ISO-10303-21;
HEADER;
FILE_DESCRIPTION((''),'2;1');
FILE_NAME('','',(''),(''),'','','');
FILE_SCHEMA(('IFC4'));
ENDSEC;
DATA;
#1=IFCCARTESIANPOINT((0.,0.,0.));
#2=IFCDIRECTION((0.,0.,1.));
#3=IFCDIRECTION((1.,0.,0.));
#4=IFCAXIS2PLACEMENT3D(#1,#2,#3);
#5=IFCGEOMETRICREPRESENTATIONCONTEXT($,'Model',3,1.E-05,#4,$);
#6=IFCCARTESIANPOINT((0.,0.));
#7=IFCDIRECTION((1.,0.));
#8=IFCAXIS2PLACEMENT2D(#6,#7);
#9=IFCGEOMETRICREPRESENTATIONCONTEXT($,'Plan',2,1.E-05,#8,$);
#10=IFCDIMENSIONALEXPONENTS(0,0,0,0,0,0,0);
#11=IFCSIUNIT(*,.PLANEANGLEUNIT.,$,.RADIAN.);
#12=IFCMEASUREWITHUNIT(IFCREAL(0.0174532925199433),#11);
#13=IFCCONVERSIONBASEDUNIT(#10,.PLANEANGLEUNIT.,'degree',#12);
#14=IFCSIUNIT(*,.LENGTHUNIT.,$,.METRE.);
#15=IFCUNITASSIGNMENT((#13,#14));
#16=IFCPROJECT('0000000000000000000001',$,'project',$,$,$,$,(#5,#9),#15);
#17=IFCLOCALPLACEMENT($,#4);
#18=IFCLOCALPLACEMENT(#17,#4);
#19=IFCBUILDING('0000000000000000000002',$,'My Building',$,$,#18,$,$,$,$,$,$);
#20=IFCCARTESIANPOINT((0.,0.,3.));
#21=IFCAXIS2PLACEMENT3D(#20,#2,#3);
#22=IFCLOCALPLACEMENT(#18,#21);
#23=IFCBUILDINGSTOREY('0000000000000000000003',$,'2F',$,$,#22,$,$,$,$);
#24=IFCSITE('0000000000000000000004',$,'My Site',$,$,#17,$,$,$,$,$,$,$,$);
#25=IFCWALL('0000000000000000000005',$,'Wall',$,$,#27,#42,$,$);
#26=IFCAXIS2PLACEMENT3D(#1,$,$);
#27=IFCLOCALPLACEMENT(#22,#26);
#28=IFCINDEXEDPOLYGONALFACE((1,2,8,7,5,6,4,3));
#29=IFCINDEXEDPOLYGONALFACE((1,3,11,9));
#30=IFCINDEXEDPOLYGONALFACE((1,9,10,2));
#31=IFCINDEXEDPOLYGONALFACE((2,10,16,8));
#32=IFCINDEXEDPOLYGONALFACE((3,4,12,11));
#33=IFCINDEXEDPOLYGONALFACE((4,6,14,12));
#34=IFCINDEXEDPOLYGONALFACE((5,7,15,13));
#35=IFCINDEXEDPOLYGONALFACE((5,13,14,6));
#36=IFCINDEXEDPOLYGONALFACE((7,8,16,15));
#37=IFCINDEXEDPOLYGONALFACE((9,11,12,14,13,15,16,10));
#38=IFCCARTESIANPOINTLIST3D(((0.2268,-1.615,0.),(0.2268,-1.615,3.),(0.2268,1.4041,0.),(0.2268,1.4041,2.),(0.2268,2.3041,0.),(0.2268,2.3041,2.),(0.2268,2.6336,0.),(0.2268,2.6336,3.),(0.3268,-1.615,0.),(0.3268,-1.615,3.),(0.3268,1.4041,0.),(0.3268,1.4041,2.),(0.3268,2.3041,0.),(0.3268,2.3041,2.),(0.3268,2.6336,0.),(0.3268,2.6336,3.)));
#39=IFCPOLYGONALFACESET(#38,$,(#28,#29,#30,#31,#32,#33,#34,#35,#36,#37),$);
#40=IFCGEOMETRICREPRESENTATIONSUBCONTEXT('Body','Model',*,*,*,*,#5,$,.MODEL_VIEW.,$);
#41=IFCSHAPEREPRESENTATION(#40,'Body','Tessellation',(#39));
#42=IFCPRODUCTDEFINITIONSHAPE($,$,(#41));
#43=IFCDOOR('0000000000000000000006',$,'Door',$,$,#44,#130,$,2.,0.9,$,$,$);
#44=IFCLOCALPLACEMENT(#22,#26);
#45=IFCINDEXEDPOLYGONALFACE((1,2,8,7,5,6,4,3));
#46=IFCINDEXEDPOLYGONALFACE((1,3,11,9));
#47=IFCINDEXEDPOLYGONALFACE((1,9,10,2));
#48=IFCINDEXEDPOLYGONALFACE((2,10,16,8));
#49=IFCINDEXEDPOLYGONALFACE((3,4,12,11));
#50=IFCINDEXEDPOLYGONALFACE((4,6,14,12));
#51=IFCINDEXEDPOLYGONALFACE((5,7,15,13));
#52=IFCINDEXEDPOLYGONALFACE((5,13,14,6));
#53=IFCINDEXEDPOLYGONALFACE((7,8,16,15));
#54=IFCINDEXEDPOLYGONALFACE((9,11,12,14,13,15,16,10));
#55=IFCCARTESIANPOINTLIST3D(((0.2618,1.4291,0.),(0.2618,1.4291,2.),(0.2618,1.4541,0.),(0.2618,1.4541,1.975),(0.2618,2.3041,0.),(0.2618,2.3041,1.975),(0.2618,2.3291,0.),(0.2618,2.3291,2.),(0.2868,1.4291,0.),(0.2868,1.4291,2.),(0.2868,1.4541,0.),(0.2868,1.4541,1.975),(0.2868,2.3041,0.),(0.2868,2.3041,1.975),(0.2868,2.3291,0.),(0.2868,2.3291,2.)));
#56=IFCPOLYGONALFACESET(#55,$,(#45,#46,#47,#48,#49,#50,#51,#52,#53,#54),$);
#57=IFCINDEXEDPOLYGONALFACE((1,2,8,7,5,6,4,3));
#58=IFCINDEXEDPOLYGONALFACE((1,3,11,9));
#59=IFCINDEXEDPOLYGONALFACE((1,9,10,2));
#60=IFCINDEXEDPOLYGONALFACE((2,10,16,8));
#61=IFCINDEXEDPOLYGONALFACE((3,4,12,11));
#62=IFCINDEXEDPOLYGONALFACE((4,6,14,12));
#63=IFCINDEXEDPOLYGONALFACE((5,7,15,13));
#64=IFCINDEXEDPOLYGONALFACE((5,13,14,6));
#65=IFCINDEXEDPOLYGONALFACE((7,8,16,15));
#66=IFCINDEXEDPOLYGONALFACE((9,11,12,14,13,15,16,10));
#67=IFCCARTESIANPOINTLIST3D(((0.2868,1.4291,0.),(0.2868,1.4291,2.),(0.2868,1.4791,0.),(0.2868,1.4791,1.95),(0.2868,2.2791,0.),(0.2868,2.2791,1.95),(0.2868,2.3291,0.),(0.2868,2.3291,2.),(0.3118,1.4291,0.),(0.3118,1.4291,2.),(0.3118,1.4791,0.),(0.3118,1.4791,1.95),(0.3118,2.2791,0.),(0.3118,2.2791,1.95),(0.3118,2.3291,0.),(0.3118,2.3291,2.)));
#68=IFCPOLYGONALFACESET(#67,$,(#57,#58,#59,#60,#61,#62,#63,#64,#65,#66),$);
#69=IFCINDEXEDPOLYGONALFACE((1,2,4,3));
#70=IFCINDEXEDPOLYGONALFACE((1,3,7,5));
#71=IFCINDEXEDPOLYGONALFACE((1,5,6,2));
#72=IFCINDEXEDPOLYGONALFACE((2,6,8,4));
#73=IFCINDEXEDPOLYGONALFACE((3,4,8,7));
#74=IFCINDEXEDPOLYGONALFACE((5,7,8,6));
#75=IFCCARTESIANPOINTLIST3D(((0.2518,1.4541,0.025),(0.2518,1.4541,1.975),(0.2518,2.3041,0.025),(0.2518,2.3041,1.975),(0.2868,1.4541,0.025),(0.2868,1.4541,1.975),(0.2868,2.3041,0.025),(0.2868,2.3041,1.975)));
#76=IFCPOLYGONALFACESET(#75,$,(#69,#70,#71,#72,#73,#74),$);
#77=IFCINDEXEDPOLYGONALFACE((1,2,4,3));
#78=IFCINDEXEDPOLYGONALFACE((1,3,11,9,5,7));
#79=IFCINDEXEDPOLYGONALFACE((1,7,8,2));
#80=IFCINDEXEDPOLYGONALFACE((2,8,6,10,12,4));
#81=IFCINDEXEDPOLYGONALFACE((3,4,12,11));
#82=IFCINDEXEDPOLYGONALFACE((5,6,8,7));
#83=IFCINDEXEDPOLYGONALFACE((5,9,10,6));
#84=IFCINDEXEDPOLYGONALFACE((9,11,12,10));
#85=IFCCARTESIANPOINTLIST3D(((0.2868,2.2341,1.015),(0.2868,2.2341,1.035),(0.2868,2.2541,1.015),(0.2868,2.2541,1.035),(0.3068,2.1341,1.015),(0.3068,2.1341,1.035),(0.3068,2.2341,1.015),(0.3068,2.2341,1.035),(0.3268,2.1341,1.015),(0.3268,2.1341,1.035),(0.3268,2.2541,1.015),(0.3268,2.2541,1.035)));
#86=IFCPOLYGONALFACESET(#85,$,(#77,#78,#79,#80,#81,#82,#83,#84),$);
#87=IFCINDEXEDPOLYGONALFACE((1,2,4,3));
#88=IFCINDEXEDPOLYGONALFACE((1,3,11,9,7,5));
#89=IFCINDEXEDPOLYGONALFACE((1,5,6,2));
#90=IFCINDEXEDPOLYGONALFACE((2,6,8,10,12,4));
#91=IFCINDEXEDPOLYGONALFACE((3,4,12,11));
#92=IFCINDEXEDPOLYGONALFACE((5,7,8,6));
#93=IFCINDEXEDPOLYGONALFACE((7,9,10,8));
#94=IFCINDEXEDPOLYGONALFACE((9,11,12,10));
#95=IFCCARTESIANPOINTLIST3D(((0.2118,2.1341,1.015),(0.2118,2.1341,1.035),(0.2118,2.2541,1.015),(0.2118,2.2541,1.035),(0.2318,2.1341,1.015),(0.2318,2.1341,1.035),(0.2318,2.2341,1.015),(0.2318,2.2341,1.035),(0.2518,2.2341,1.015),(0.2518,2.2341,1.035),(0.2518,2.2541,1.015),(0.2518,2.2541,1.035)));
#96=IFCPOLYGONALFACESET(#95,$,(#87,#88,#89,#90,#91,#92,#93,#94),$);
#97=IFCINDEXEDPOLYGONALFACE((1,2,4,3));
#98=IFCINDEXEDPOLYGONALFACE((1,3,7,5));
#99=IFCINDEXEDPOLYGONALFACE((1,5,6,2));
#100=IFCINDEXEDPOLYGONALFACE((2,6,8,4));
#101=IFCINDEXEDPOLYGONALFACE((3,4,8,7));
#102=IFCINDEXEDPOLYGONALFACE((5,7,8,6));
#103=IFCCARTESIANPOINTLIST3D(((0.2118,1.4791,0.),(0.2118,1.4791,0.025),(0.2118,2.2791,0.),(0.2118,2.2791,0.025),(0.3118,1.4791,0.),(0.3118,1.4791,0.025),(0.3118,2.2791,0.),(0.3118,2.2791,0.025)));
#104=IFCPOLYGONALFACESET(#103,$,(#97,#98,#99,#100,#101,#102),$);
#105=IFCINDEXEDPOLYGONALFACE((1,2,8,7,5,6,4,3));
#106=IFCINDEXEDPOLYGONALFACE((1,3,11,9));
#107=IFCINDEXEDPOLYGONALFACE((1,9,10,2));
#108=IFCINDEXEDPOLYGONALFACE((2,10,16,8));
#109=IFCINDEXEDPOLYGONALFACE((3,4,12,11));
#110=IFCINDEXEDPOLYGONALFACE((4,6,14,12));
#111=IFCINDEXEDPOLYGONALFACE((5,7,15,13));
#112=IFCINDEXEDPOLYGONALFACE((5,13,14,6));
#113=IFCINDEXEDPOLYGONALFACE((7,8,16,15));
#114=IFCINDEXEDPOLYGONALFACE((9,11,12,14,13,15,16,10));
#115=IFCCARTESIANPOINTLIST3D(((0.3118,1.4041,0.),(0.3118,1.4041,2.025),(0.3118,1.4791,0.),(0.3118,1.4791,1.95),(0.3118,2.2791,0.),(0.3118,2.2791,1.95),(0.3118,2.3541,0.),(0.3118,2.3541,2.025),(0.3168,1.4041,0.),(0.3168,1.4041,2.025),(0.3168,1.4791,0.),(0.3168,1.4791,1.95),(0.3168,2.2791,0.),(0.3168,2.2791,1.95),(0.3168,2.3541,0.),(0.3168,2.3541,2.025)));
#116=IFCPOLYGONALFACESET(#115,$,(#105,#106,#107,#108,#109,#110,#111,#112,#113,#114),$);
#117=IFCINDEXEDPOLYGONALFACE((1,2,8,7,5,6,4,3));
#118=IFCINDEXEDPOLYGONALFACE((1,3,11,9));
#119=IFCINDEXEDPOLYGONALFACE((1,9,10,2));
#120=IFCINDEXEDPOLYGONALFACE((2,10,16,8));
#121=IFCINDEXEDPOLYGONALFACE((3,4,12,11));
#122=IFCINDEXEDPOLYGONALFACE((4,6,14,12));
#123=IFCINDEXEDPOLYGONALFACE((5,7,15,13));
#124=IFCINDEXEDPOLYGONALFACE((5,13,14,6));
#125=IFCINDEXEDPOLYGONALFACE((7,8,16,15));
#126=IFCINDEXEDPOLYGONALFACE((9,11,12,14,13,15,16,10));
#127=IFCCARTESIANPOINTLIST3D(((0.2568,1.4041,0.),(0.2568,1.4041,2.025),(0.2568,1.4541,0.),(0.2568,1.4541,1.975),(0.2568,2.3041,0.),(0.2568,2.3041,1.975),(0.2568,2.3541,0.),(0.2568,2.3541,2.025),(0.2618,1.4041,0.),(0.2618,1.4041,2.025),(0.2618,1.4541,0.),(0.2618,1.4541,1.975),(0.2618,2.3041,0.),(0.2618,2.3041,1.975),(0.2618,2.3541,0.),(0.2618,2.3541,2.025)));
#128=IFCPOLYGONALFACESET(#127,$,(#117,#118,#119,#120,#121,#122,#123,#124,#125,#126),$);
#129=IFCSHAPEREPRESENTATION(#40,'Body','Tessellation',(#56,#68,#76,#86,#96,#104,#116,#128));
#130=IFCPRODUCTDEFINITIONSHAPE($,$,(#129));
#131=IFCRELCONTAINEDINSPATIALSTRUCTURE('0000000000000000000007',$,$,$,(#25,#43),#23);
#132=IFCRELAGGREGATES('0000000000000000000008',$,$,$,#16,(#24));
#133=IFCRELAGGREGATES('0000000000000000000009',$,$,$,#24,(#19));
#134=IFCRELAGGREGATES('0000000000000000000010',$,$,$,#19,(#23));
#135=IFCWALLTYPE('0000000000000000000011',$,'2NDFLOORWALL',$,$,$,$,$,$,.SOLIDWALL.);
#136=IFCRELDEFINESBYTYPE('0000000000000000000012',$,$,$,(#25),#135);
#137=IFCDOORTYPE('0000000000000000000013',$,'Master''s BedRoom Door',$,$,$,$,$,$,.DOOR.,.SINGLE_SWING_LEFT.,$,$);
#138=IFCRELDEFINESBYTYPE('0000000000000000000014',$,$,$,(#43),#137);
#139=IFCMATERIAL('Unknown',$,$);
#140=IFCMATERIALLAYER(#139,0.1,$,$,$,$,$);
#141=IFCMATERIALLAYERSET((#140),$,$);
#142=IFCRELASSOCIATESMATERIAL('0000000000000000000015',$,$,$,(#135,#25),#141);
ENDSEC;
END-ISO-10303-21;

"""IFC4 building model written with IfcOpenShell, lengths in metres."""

from ifc_helpers import new_model, entity, si_unit, converted_unit, frame, origin_with_axes, origin_2d_with_axis, place, context, subcontext, project, spatial, line, indexed_curve, outline, extrude, shape, source, transform, mapped, material, layer, layer_set, layer_usage, type_object, type_shapes, element, fill, save


model = new_model("IFC4")

# Units and contexts
model_context = context("Model", 3, precision=1e-05, world=origin_with_axes())
plan_context = context("Plan", 2, precision=1e-05, world=origin_2d_with_axis())
body_context_1 = subcontext(model_context, "Body", "Model", "MODEL_VIEW")
body_context_2 = subcontext(plan_context, "Body", "Plan", "PLAN_VIEW")
ifc_project = project(units=[converted_unit("PLANEANGLEUNIT", "degree", entity("IfcReal", 0.0174532925199433), si_unit("PLANEANGLEUNIT", "RADIAN"), dimensions=[0, 0, 0, 0, 0, 0, 0]), si_unit("LENGTHUNIT", "METRE")], contexts=[model_context, plan_context])

# Site, building, storey
site_placement = place(None, origin_with_axes())
site = spatial("IfcSite", under=ifc_project, at=site_placement, Name="My Site")
building_placement = place(site_placement, origin_with_axes())
building = spatial("IfcBuilding", under=site, at=building_placement, Name="My Building")
storey_placement = place(building_placement, frame((0.0, 0.0, 3.0), z_axis=(0.0, 0.0, 1.0), x_axis=(1.0, 0.0, 0.0)))
storey = spatial("IfcBuildingStorey", under=building, at=storey_placement, Name="2F")

# Shared definitions
ifc_material = material(Name="Unknown")

# Shared definitions
ifc_layer_1 = layer(ifc_material, 0.1)
ifc_layer_set_1 = layer_set([ifc_layer_1])
wall_type_1 = type_object("IfcWallType", Name="2NDFLOORWALL", PredefinedType="SOLIDWALL", material=ifc_layer_set_1)

# Wall, opening, door
shared_shape_1 = source(origin_with_axes(), body_context_1, "Body", "SweptSolid", [
    extrude(outline(indexed_curve([(0.0, 0.0), (0.9, 0.0), (0.9, 2.0), (0.0, 2.0)], segments=[line(1, 2, 3, 4, 1)])), frame((0.0, -0.6, 0.0), z_axis=(0.0, -1.0, 0.0), x_axis=(1.0, 0.0, 0.0)), (0.0, 0.0, -1.0), 1.2),
])
door_type_1 = type_object("IfcDoorType", Name="Master's BedRoom Door", OperationType="SINGLE_SWING_LEFT", PredefinedType="DOOR")
shared_shape_2 = source(origin_with_axes(), body_context_1, "Body", "SweptSolid", [
    extrude(outline(indexed_curve([(0.0, 0.0), (0.0, 2.0), (0.9, 2.0), (0.9, 0.0), (0.875, 0.0), (0.875, 1.975), (0.025, 1.975), (0.025, 0.0)], segments=[line(1, 2, 3, 4, 5, 6, 7, 8, 1)])), frame((0.0, 0.025, 0.0), z_axis=(0.0, -1.0, 0.0), x_axis=(1.0, 0.0, 0.0)), (0.0, 0.0, -1.0), 0.025),
    extrude(outline(indexed_curve([(0.0, 0.0), (0.0, 2.0), (0.9, 2.0), (0.9, 0.0), (0.85, 0.0), (0.85, 1.95), (0.05, 1.95), (0.05, 0.0)], segments=[line(1, 2, 3, 4, 5, 6, 7, 8, 1)])), frame((0.0, 0.0, 0.0), z_axis=(0.0, -1.0, 0.0), x_axis=(1.0, 0.0, 0.0)), (0.0, 0.0, -1.0), 0.025),
    extrude(outline(indexed_curve([(0.0, 0.0), (0.85, 0.0), (0.85, 0.035), (0.0, 0.035)], segments=[line(1, 2, 3, 4, 1)])), frame((0.025, 0.025, 0.025), z_axis=(0.0, 0.0, 1.0), x_axis=(1.0, 0.0, 0.0)), (0.0, 0.0, 1.0), 1.95),
    extrude(outline(indexed_curve([(0.0, 0.0), (0.0, -0.04), (-0.12, -0.04), (-0.12, -0.02), (-0.02, -0.02), (-0.02, 0.0)], segments=[line(1, 2, 3, 4, 5, 6, 1)])), frame((0.825, 0.025, 1.015), z_axis=(0.0, 0.0, 1.0), x_axis=(1.0, 0.0, 0.0)), (0.0, 0.0, 1.0), 0.02),
    extrude(outline(indexed_curve([(0.0, 0.0), (0.0, 0.04), (-0.12, 0.04), (-0.12, 0.02), (-0.02, 0.02), (-0.02, 0.0)], segments=[line(1, 2, 3, 4, 5, 6, 1)])), frame((0.825, 0.06, 1.015), z_axis=(0.0, 0.0, 1.0), x_axis=(1.0, 0.0, 0.0)), (0.0, 0.0, 1.0), 0.02),
    extrude(outline(indexed_curve([(0.0, 0.0), (0.8, 0.0), (0.8, 0.1), (0.0, 0.1)], segments=[line(1, 2, 3, 4, 1)])), frame((0.05, 0.0, 0.0), z_axis=(0.0, 0.0, 1.0), x_axis=(1.0, 0.0, 0.0)), (0.0, 0.0, 1.0), 0.025),
    extrude(outline(indexed_curve([(0.0, 0.0), (0.0, 2.025), (0.95, 2.025), (0.95, 0.0), (0.875, 0.0), (0.875, 1.95), (0.075, 1.95), (0.075, 0.0)], segments=[line(1, 2, 3, 4, 5, 6, 7, 8, 1)])), frame((-0.025, -0.005, 0.0), z_axis=(0.0, -1.0, 0.0), x_axis=(1.0, 0.0, 0.0)), (0.0, 0.0, -1.0), 0.005),
    extrude(outline(indexed_curve([(0.0, 0.0), (0.0, 2.025), (0.95, 2.025), (0.95, 0.0), (0.9, 0.0), (0.9, 1.975), (0.05, 1.975), (0.05, 0.0)], segments=[line(1, 2, 3, 4, 5, 6, 7, 8, 1)])), frame((-0.025, 0.05, 0.0), z_axis=(0.0, -1.0, 0.0), x_axis=(1.0, 0.0, 0.0)), (0.0, 0.0, -1.0), 0.005),
])
shared_shape_3 = source(origin_with_axes(), body_context_2, "Body", "Curve2D", [
    entity("IfcIndexedPolyCurve", entity("IfcCartesianPointList2D", [[0.0, 0.0], [0.0, 0.05], [0.025, 0.05], [0.025, 0.025], [0.05, 0.025], [0.05, 0.0]]), [entity("IfcLineIndex", [1, 2, 3, 4, 5, 6, 1])]),
    entity("IfcIndexedPolyCurve", entity("IfcCartesianPointList2D", [[0.9, 0.0], [0.9, 0.05], [0.875, 0.05], [0.875, 0.025], [0.85, 0.025], [0.85, 0.0]]), [entity("IfcLineIndex", [1, 2, 3, 4, 5, 6, 1])]),
    entity("IfcTrimmedCurve", entity("IfcEllipse", entity("IfcAxis2Placement2D", entity("IfcCartesianPoint", [0.06, 0.05]), entity("IfcDirection", [1.0, 0.0])), 0.815, 0.85), [entity("IfcCartesianPoint", [0.875, 0.05])], [entity("IfcCartesianPoint", [0.06, 0.9])], True, "CARTESIAN"),
    entity("IfcIndexedPolyCurve", entity("IfcCartesianPointList2D", [[0.025, 0.05], [0.06, 0.05], [0.06, 0.9], [0.025, 0.9]]), [entity("IfcLineIndex", [1, 2, 3, 4, 1])]),
])
type_shapes(door_type_1, [shared_shape_2, shared_shape_3])
ifc_layer_usage_1 = layer_usage(ifc_layer_set_1, "AXIS2", "POSITIVE", 0.0)
wall_1_placement = place(storey_placement, frame((0.2268, 2.6336, 0.0), z_axis=(0.0, 0.0, 1.0), x_axis=(0.0, -1.0, 0.0)))
wall_1 = element("IfcWall", 1, at=wall_1_placement, inside=storey, type_object=wall_type_1, material=ifc_layer_usage_1, Name="Wall", context=body_context_1, shape_type="SweptSolid", body=[
    extrude(outline(indexed_curve([(0.0, 0.0), (0.0, 0.1), (4.2486, 0.1), (4.2486, 0.0)], segments=[line(1, 2, 3, 4, 1)])), origin_with_axes(), (0.0, 0.0, 1.0), 3.0),
])
opening_1_placement = place(wall_1_placement, frame((0.3295, 0.0, 0.0), z_axis=(0.0, 0.0, 1.0), x_axis=(1.0, 0.0, 0.0)))
opening_1 = element("IfcOpeningElement", 2, at=opening_1_placement, cuts=wall_1, PredefinedType="OPENING", context=body_context_1, shape_type="MappedRepresentation", body=[
    mapped(shared_shape_1, transform((0.0, 0.0, 0.0), x_axis=(1.0, 0.0, 0.0), y_axis=(0.0, 1.0, 0.0), z_axis=(0.0, 0.0, 1.0), scale=1.0)),
])
door_1_placement = place(opening_1_placement, frame((0.875, 0.085, 0.0), z_axis=(0.0, 0.0, 1.0), x_axis=(-1.0, 0.0, 0.0)))
door_1 = element("IfcDoor", 3, at=door_1_placement, inside=storey, type_object=door_type_1, Name="Door", OverallHeight=2.0, OverallWidth=0.9, shapes=[
    shape(body_context_1, "Body", "MappedRepresentation", [mapped(shared_shape_2, transform((0.0, 0.0, 0.0), x_axis=(1.0, 0.0, 0.0), y_axis=(0.0, 1.0, 0.0), z_axis=(0.0, 0.0, 1.0), scale=1.0))]),
    shape(body_context_2, "Body", "MappedRepresentation", [mapped(shared_shape_3, transform((0.0, 0.0, 0.0), x_axis=(1.0, 0.0, 0.0), y_axis=(0.0, 1.0, 0.0), z_axis=(0.0, 0.0, 1.0), scale=1.0))]),
])
fill(opening_1, door_1)

save(model, "model.ifc")
